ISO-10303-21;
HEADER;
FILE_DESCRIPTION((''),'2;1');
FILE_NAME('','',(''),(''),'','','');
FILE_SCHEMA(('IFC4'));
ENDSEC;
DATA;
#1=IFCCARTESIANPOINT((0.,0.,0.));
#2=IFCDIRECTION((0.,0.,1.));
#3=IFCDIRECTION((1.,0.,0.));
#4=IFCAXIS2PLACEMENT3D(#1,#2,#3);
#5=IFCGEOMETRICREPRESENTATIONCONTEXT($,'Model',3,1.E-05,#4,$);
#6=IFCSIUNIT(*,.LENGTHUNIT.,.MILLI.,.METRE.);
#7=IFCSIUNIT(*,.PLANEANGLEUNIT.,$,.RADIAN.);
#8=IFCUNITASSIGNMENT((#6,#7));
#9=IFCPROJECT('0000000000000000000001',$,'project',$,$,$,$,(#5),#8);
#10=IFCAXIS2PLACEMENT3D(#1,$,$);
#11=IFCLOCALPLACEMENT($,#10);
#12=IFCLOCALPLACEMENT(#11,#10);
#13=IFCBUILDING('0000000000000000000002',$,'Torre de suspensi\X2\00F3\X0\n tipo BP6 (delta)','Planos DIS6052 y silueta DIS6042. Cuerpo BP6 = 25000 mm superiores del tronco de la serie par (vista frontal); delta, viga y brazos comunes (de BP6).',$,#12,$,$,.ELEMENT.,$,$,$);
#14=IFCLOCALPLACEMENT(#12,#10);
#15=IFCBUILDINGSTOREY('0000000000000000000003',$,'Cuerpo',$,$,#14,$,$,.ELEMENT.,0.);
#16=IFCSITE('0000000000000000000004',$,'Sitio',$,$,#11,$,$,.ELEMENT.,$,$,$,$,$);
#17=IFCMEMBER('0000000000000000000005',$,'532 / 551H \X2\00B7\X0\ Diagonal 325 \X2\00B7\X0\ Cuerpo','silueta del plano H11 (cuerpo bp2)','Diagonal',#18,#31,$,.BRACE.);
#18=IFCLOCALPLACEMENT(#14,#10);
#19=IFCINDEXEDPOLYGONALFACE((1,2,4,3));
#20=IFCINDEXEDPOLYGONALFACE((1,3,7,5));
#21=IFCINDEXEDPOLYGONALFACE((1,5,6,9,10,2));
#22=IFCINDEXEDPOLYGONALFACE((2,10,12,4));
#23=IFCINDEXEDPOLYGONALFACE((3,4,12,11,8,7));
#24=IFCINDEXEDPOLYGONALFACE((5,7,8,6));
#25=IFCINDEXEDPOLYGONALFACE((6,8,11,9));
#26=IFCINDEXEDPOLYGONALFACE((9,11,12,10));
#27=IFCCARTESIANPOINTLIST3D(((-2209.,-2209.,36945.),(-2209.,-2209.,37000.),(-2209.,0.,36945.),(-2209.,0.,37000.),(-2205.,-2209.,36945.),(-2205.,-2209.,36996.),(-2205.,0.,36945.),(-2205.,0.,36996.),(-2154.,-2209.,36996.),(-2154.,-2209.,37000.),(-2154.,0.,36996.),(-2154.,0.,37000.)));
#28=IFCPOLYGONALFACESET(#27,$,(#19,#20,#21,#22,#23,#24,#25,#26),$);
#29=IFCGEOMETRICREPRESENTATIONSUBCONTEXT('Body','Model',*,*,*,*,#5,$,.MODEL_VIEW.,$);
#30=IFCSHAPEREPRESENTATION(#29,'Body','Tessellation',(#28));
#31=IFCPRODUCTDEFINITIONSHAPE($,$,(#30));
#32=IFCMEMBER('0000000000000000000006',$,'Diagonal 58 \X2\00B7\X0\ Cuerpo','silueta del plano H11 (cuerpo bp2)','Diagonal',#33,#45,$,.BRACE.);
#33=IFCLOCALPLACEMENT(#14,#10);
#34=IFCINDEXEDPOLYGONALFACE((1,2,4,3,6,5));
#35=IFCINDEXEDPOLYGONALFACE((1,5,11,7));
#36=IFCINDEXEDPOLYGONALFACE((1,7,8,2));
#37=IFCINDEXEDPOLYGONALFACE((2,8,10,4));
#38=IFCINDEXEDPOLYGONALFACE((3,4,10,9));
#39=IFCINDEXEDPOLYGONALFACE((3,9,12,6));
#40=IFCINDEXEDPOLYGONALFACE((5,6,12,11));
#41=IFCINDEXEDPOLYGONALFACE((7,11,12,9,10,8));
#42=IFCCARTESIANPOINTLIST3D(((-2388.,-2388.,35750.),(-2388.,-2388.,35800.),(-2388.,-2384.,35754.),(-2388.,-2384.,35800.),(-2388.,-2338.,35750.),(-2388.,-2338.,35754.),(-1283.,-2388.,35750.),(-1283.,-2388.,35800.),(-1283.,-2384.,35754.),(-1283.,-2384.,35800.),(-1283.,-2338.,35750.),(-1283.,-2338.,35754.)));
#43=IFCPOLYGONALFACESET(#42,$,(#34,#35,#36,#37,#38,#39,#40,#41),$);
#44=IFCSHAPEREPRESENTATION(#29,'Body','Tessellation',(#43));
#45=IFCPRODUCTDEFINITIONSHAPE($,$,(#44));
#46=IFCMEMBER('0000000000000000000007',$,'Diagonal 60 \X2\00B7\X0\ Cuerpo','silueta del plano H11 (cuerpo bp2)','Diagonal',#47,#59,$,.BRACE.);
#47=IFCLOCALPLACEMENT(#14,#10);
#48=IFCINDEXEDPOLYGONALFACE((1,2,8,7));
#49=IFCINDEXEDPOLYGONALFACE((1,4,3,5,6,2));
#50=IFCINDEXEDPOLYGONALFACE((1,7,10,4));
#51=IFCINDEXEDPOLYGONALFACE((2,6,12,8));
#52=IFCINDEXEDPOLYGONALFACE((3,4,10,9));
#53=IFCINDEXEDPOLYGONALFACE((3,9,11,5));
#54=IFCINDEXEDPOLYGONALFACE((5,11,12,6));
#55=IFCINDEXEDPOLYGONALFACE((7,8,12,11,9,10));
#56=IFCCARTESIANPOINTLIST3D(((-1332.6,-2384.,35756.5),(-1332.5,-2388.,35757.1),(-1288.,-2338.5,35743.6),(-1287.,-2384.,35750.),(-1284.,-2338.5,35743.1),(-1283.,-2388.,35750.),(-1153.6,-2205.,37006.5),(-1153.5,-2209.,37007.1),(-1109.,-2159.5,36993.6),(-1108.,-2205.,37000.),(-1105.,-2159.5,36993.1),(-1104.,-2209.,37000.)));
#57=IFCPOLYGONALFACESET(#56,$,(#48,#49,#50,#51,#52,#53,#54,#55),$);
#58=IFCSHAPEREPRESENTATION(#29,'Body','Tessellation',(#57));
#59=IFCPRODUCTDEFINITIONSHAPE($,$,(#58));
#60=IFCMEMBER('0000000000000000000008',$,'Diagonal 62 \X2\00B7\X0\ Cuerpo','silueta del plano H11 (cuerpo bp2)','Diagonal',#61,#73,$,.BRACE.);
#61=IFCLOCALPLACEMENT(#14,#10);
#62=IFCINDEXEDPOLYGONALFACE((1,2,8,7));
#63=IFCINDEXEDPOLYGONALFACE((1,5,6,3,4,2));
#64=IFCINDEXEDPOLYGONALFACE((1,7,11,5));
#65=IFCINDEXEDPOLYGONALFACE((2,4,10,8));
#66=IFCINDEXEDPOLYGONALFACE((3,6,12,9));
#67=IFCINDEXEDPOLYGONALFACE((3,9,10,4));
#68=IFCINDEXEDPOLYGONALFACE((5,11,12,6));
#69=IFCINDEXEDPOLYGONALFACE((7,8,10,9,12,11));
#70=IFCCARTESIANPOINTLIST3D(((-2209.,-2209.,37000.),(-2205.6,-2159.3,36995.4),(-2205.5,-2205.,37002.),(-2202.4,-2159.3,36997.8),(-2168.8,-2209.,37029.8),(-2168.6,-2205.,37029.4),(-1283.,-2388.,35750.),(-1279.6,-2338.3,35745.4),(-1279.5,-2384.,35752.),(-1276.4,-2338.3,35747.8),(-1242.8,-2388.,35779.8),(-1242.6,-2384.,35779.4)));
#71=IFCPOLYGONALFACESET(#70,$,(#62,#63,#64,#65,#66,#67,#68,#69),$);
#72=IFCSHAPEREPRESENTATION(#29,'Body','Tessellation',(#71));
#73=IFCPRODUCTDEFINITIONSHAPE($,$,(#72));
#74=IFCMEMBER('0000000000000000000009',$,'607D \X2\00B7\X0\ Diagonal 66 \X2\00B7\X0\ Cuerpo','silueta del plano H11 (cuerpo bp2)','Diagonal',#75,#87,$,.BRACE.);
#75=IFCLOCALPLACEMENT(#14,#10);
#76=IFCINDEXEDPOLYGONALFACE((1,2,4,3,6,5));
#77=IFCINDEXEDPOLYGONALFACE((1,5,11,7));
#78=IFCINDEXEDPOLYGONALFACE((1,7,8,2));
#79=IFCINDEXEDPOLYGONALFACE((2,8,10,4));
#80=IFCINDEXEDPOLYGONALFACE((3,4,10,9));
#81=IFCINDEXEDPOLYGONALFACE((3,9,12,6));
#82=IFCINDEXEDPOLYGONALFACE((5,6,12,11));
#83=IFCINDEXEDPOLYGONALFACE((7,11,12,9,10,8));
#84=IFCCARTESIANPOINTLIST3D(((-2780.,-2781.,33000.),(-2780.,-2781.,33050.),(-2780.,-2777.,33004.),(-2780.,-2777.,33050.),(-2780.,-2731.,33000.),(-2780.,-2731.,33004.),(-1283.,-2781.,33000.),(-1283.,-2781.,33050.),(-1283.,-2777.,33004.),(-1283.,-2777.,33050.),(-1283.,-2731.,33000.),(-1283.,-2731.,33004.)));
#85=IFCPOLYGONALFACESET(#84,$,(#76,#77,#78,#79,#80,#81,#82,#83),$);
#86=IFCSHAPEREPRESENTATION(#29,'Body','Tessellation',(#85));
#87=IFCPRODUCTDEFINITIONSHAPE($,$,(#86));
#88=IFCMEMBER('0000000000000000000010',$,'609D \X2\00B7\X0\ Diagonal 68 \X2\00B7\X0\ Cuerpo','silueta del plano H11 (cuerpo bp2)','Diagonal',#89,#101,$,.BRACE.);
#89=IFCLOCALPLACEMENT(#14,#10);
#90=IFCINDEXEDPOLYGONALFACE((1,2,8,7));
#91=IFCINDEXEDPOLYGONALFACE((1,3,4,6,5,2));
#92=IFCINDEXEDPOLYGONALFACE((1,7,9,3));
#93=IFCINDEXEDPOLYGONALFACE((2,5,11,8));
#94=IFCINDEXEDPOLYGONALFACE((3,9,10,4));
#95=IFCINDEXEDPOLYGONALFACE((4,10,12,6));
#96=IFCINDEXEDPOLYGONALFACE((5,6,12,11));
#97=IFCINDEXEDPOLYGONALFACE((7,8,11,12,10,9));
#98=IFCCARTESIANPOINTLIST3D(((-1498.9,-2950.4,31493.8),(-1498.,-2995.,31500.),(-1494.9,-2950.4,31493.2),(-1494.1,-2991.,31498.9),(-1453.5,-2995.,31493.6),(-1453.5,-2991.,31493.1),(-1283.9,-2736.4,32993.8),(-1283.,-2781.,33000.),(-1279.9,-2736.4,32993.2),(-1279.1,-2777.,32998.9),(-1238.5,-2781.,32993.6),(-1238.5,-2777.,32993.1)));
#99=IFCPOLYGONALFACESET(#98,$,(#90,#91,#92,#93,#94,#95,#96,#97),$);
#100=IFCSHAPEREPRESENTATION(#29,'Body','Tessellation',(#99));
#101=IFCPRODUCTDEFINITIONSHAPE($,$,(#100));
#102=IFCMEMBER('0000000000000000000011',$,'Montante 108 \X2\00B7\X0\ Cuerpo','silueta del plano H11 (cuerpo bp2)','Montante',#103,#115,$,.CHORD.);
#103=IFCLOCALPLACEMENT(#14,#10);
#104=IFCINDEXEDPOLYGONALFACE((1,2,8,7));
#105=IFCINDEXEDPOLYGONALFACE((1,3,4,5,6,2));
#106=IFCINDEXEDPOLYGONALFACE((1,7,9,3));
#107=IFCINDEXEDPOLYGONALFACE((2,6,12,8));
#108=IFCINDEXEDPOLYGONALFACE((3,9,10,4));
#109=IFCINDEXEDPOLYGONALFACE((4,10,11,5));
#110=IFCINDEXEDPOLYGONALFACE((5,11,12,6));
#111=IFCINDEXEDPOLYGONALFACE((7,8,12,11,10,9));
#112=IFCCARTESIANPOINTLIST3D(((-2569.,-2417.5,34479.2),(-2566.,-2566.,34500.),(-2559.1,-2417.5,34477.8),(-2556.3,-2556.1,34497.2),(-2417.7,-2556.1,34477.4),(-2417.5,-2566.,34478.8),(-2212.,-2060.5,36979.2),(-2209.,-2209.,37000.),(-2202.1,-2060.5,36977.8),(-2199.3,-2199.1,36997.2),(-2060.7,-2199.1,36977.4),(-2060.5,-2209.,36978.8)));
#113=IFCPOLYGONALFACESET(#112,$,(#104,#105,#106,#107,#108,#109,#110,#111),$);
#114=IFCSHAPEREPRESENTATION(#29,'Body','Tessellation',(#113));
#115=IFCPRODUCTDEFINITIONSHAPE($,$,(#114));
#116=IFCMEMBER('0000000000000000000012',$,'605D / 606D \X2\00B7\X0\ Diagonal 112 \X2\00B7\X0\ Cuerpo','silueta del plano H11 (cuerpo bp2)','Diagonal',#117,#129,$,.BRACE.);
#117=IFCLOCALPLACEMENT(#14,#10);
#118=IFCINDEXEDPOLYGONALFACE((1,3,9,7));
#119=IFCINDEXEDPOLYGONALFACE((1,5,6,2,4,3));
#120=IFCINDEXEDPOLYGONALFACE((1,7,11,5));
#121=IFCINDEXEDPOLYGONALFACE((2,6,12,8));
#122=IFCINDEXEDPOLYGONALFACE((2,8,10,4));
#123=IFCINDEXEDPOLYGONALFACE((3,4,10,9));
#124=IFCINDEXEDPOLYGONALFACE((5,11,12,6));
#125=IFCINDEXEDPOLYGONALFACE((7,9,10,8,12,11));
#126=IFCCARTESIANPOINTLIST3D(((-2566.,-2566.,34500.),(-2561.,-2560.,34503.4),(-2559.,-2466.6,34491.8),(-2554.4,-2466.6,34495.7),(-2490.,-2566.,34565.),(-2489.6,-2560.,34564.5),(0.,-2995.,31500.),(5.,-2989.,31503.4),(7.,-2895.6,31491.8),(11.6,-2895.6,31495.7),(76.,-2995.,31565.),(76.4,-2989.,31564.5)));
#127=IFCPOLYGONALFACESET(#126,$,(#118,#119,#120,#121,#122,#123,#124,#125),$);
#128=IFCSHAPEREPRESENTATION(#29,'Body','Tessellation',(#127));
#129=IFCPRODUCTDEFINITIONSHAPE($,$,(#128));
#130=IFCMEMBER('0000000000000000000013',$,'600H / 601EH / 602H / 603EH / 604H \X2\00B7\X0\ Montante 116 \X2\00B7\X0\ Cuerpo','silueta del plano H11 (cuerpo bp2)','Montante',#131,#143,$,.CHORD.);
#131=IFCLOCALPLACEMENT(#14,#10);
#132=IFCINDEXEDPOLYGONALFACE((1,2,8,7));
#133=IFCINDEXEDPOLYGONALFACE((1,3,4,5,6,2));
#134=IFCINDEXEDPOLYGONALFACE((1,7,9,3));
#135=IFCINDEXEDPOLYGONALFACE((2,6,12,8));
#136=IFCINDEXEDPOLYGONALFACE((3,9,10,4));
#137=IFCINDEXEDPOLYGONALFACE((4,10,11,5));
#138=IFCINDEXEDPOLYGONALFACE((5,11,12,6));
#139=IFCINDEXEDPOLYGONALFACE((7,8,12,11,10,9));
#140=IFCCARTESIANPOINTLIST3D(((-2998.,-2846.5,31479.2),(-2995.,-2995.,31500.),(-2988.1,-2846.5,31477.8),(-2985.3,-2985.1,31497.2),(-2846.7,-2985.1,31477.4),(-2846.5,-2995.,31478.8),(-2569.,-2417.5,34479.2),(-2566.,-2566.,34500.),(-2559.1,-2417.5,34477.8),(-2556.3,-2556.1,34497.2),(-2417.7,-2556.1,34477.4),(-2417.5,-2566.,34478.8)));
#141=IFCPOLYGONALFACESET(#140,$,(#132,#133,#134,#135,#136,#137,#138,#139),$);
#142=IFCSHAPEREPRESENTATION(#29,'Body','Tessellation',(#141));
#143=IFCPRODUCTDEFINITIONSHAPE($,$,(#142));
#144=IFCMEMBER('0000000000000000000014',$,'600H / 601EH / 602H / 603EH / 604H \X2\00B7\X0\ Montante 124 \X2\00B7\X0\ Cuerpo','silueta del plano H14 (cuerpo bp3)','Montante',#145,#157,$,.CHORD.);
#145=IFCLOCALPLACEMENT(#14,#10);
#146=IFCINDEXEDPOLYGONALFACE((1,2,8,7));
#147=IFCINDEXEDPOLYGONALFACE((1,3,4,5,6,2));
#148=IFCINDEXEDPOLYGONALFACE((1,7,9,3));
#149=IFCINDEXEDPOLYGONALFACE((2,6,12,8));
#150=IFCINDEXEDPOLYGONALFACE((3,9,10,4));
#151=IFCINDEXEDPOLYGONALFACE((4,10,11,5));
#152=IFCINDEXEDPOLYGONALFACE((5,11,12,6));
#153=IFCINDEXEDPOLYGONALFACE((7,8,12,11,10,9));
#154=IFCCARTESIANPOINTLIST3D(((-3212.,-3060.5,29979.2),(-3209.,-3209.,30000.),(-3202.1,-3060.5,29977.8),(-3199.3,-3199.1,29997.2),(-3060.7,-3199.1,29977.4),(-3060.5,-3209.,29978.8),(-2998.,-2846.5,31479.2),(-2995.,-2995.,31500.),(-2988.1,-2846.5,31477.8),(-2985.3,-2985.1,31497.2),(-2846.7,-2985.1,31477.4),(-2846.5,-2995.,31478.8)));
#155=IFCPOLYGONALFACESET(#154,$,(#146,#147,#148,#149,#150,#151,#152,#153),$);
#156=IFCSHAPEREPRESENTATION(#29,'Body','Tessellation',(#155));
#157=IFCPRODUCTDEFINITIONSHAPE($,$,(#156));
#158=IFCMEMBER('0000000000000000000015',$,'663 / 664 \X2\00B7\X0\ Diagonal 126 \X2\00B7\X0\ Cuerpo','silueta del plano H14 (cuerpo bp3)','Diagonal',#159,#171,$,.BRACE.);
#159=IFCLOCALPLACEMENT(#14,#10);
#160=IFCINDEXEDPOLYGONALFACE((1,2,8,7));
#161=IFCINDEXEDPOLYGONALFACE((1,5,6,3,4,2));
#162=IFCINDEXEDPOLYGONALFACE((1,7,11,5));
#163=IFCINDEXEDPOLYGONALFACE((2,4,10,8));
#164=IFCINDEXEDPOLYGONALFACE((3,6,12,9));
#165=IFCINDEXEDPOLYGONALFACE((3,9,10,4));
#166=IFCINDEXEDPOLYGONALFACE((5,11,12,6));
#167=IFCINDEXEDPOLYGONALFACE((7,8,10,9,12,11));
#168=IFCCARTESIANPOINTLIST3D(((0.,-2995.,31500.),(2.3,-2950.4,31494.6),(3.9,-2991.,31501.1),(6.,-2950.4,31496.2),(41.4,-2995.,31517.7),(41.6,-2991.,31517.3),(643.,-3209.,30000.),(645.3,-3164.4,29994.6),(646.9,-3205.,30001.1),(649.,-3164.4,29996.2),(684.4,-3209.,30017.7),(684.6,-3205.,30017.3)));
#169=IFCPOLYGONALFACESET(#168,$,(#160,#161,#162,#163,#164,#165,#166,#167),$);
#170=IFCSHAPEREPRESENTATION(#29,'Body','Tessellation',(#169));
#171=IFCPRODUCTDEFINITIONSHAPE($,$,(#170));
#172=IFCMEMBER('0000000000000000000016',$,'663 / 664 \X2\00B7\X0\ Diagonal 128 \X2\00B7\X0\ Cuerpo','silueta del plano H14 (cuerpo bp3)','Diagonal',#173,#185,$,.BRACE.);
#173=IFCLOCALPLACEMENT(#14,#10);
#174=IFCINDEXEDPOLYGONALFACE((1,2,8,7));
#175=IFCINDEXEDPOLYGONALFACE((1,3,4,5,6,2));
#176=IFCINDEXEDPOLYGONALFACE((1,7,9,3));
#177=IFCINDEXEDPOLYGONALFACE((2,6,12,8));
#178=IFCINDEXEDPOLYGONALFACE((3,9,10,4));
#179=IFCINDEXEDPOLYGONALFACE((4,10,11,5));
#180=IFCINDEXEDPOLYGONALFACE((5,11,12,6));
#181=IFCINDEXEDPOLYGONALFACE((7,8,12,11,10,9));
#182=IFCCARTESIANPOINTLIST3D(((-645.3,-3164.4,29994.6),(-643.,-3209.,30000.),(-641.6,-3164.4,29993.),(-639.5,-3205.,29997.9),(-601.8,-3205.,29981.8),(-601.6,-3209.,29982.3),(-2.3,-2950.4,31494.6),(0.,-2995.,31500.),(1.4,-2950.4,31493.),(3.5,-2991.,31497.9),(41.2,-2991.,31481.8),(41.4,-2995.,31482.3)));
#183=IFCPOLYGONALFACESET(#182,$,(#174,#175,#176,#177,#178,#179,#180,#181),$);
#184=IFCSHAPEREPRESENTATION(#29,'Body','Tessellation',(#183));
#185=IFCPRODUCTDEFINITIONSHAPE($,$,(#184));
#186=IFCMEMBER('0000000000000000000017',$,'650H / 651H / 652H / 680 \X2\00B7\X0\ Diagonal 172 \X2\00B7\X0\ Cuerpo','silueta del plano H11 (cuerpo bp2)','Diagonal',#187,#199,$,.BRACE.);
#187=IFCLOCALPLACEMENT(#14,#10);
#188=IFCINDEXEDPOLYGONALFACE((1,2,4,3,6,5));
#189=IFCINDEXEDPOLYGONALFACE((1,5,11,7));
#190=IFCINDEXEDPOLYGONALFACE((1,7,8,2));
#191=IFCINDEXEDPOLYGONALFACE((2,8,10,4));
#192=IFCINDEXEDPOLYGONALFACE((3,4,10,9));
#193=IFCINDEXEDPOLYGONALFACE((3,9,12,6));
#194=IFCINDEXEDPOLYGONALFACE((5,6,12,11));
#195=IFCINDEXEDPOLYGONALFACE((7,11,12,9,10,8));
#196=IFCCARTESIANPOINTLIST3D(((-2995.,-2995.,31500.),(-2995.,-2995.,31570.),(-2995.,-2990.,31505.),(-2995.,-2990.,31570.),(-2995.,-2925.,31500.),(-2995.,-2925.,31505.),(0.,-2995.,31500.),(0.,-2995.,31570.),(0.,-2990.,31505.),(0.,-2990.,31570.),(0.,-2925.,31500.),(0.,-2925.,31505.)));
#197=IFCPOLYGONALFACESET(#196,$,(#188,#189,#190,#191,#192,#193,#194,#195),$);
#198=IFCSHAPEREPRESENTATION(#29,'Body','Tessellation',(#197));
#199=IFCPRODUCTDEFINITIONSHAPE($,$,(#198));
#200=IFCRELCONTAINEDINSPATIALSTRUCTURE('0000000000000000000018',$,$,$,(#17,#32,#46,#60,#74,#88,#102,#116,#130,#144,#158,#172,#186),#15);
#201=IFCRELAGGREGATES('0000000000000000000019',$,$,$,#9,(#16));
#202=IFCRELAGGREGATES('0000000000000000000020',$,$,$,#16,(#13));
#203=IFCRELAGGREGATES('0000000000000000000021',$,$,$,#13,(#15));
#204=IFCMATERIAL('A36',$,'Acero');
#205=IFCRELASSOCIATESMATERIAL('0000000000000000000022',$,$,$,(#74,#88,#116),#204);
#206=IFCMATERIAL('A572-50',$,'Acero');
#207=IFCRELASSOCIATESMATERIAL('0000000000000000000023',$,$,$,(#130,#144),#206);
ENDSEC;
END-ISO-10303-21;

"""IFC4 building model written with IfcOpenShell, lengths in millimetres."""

from ifc_helpers import new_model, si_unit, frame, frame_2d, origin, origin_with_axes, place, context, subcontext, project, spatial, l_section, extrude, material, element, save


model = new_model("IFC4")

# Units and contexts
model_context = context("Model", 3, precision=1e-05, world=origin_with_axes())
body_context = subcontext(model_context, "Body", "Model", "MODEL_VIEW")
ifc_project = project(units=[si_unit("LENGTHUNIT", "METRE", prefix="MILLI"), si_unit("PLANEANGLEUNIT", "RADIAN")], contexts=[model_context])

# Site, building, storey
site_placement = place(None, origin())
site = spatial("IfcSite", under=ifc_project, at=site_placement, Name="Sitio", CompositionType="ELEMENT")
building_placement = place(site_placement, origin())
building = spatial("IfcBuilding", under=site, at=building_placement, Name="Torre de suspensión tipo BP6 (delta)", Description="Planos DIS6052 y silueta DIS6042. Cuerpo BP6 = 25000 mm superiores del tronco de la serie par (vista frontal); delta, viga y brazos comunes (de BP6).", CompositionType="ELEMENT")
storey_placement = place(building_placement, origin())
storey = spatial("IfcBuildingStorey", under=building, at=storey_placement, Name="Cuerpo", CompositionType="ELEMENT", Elevation=0.0)

# Members
member_1_placement = place(storey_placement, frame((-2209.0, -2209.0, 37000.0), z_axis=(0.0, 1.0, 0.0), x_axis=(1.0, 0.0, 0.0)))
element("IfcMember", 1, at=member_1_placement, inside=storey, Name="532 / 551H · Diagonal 325 · Cuerpo", Description="silueta del plano H11 (cuerpo bp2)", ObjectType="Diagonal", PredefinedType="BRACE", context=body_context, shape_type="SweptSolid", body=[
    extrude(l_section(Depth=55.0, Width=55.0, Thickness=4.0, at=frame_2d((27.5, 27.5))), None, (0.0, 0.0, 1.0), 2209.0),
])
member_2_placement = place(storey_placement, frame((-2388.0, -2388.0, 35750.0), z_axis=(1.0, 0.0, 0.0), x_axis=(0.0, 1.0, 0.0)))
element("IfcMember", 2, at=member_2_placement, inside=storey, Name="Diagonal 58 · Cuerpo", Description="silueta del plano H11 (cuerpo bp2)", ObjectType="Diagonal", PredefinedType="BRACE", context=body_context, shape_type="SweptSolid", body=[
    extrude(l_section(Depth=50.0, Width=50.0, Thickness=4.0, at=frame_2d((25.0, 25.0))), None, (0.0, 0.0, 1.0), 1105.0),
])
member_3_placement = place(storey_placement, frame((-1283.0, -2388.0, 35750.0), z_axis=(0.140351, 0.140351, 0.980104), x_axis=(-0.019895, 0.990102, -0.138934)))
element("IfcMember", 3, at=member_3_placement, inside=storey, Name="Diagonal 60 · Cuerpo", Description="silueta del plano H11 (cuerpo bp2)", ObjectType="Diagonal", PredefinedType="BRACE", context=body_context, shape_type="SweptSolid", body=[
    extrude(l_section(Depth=50.0, Width=50.0, Thickness=4.0, at=frame_2d((25.0, 25.0))), None, (0.0, 0.0, 1.0), 1275.4),
])
member_4_placement = place(storey_placement, frame((-2209.0, -2209.0, 37000.0), z_axis=(0.591356, -0.114312, -0.798267), x_axis=(0.068045, 0.993445, -0.091854)))
element("IfcMember", 4, at=member_4_placement, inside=storey, Name="Diagonal 62 · Cuerpo", Description="silueta del plano H11 (cuerpo bp2)", ObjectType="Diagonal", PredefinedType="BRACE", context=body_context, shape_type="SweptSolid", body=[
    extrude(l_section(Depth=50.0, Width=50.0, Thickness=4.0, at=frame_2d((25.0, 25.0))), None, (0.0, 0.0, 1.0), 1565.9),
])
ifc_material_1 = material(Name="A36", Category="Acero")
member_5_placement = place(storey_placement, frame((-2780.0, -2781.0, 33000.0), z_axis=(1.0, 0.0, 0.0), x_axis=(0.0, 1.0, 0.0)))
element("IfcMember", 5, at=member_5_placement, inside=storey, material=ifc_material_1, Name="607D · Diagonal 66 · Cuerpo", Description="silueta del plano H11 (cuerpo bp2)", ObjectType="Diagonal", PredefinedType="BRACE", context=body_context, shape_type="SweptSolid", body=[
    extrude(l_section(Depth=50.0, Width=50.0, Thickness=4.0, at=frame_2d((25.0, 25.0))), None, (0.0, 0.0, 1.0), 1497.0),
])
member_6_placement = place(storey_placement, frame((-1283.0, -2781.0, 33000.0), z_axis=(-0.140489, -0.139836, -0.980157), x_axis=(-0.01984, 0.990175, -0.138421)))
element("IfcMember", 6, at=member_6_placement, inside=storey, material=ifc_material_1, Name="609D · Diagonal 68 · Cuerpo", Description="silueta del plano H11 (cuerpo bp2)", ObjectType="Diagonal", PredefinedType="BRACE", context=body_context, shape_type="SweptSolid", body=[
    extrude(l_section(Depth=45.0, Width=45.0, Thickness=4.0, at=frame_2d((22.5, 22.5))), None, (0.0, 0.0, 1.0), 1530.4),
])
member_7_placement = place(storey_placement, frame((-2209.0, -2209.0, 37000.0), z_axis=(-0.139974, -0.139974, -0.980211), x_axis=(-0.019788, 0.990155, -0.138568)))
element("IfcMember", 7, at=member_7_placement, inside=storey, Name="Montante 108 · Cuerpo", Description="silueta del plano H11 (cuerpo bp2)", ObjectType="Montante", PredefinedType="CHORD", context=body_context, shape_type="SweptSolid", body=[
    extrude(l_section(Depth=150.0, Width=150.0, Thickness=10.0, at=frame_2d((75.0, 75.0))), None, (0.0, 0.0, 1.0), 2550.5),
])
member_8_placement = place(storey_placement, frame((-2566.0, -2566.0, 34500.0), z_axis=(0.646194, -0.108035, -0.755488), x_axis=(0.070222, 0.994147, -0.082099)))
element("IfcMember", 8, at=member_8_placement, inside=storey, material=ifc_material_1, Name="605D / 606D · Diagonal 112 · Cuerpo", Description="silueta del plano H11 (cuerpo bp2)", ObjectType="Diagonal", PredefinedType="BRACE", context=body_context, shape_type="SweptSolid", body=[
    extrude(l_section(Depth=100.0, Width=100.0, Thickness=6.0, at=frame_2d((50.0, 50.0))), None, (0.0, 0.0, 1.0), 3970.9),
])
ifc_material_2 = material(Name="A572-50", Category="Acero")
member_9_placement = place(storey_placement, frame((-2566.0, -2566.0, 34500.0), z_axis=(-0.140163, -0.140163, -0.980158), x_axis=(-0.019841, 0.990129, -0.138751)))
element("IfcMember", 9, at=member_9_placement, inside=storey, material=ifc_material_2, Name="600H / 601EH / 602H / 603EH / 604H · Montante 116 · Cuerpo", Description="silueta del plano H11 (cuerpo bp2)", ObjectType="Montante", PredefinedType="CHORD", context=body_context, shape_type="SweptSolid", body=[
    extrude(l_section(Depth=150.0, Width=150.0, Thickness=10.0, at=frame_2d((75.0, 75.0))), None, (0.0, 0.0, 1.0), 3060.7),
])
member_10_placement = place(storey_placement, frame((-2995.0, -2995.0, 31500.0), z_axis=(-0.139849, -0.139849, -0.980247), x_axis=(-0.019752, 0.990173, -0.138447)))
element("IfcMember", 10, at=member_10_placement, inside=storey, material=ifc_material_2, Name="600H / 601EH / 602H / 603EH / 604H · Montante 124 · Cuerpo", Description="silueta del plano H14 (cuerpo bp3)", ObjectType="Montante", PredefinedType="CHORD", context=body_context, shape_type="SweptSolid", body=[
    extrude(l_section(Depth=150.0, Width=150.0, Thickness=10.0, at=frame_2d((75.0, 75.0))), None, (0.0, 0.0, 1.0), 1530.2),
])
for number, where, z_axis, x_axis, name in (
    (11, (0.0, -2995.0, 31500.0), (0.390649, -0.130014, -0.911312), (0.051225, 0.991512, -0.119497), "663 / 664 · Diagonal 126 · Cuerpo"),
    (12, (0.0, -2995.0, 31500.0), (-0.390649, -0.130014, -0.911312), (-0.051225, 0.991512, -0.119497), "663 / 664 · Diagonal 128 · Cuerpo"),
):
    element("IfcMember", number, at=place(storey_placement, frame(where, z_axis=z_axis, x_axis=x_axis)), inside=storey, Name=name, Description="silueta del plano H14 (cuerpo bp3)", ObjectType="Diagonal", PredefinedType="BRACE", context=body_context, shape_type="SweptSolid", body=[
        extrude(l_section(Depth=45.0, Width=45.0, Thickness=4.0, at=frame_2d((22.5, 22.5))), None, (0.0, 0.0, 1.0), 1646.0),
    ])
member_11_placement = place(storey_placement, frame((-2995.0, -2995.0, 31500.0), z_axis=(1.0, 0.0, 0.0), x_axis=(0.0, 1.0, 0.0)))
element("IfcMember", 13, at=member_11_placement, inside=storey, Name="650H / 651H / 652H / 680 · Diagonal 172 · Cuerpo", Description="silueta del plano H11 (cuerpo bp2)", ObjectType="Diagonal", PredefinedType="BRACE", context=body_context, shape_type="SweptSolid", body=[
    extrude(l_section(Depth=70.0, Width=70.0, Thickness=5.0, at=frame_2d((35.0, 35.0))), None, (0.0, 0.0, 1.0), 2995.0),
])

save(model, "model.ifc")
